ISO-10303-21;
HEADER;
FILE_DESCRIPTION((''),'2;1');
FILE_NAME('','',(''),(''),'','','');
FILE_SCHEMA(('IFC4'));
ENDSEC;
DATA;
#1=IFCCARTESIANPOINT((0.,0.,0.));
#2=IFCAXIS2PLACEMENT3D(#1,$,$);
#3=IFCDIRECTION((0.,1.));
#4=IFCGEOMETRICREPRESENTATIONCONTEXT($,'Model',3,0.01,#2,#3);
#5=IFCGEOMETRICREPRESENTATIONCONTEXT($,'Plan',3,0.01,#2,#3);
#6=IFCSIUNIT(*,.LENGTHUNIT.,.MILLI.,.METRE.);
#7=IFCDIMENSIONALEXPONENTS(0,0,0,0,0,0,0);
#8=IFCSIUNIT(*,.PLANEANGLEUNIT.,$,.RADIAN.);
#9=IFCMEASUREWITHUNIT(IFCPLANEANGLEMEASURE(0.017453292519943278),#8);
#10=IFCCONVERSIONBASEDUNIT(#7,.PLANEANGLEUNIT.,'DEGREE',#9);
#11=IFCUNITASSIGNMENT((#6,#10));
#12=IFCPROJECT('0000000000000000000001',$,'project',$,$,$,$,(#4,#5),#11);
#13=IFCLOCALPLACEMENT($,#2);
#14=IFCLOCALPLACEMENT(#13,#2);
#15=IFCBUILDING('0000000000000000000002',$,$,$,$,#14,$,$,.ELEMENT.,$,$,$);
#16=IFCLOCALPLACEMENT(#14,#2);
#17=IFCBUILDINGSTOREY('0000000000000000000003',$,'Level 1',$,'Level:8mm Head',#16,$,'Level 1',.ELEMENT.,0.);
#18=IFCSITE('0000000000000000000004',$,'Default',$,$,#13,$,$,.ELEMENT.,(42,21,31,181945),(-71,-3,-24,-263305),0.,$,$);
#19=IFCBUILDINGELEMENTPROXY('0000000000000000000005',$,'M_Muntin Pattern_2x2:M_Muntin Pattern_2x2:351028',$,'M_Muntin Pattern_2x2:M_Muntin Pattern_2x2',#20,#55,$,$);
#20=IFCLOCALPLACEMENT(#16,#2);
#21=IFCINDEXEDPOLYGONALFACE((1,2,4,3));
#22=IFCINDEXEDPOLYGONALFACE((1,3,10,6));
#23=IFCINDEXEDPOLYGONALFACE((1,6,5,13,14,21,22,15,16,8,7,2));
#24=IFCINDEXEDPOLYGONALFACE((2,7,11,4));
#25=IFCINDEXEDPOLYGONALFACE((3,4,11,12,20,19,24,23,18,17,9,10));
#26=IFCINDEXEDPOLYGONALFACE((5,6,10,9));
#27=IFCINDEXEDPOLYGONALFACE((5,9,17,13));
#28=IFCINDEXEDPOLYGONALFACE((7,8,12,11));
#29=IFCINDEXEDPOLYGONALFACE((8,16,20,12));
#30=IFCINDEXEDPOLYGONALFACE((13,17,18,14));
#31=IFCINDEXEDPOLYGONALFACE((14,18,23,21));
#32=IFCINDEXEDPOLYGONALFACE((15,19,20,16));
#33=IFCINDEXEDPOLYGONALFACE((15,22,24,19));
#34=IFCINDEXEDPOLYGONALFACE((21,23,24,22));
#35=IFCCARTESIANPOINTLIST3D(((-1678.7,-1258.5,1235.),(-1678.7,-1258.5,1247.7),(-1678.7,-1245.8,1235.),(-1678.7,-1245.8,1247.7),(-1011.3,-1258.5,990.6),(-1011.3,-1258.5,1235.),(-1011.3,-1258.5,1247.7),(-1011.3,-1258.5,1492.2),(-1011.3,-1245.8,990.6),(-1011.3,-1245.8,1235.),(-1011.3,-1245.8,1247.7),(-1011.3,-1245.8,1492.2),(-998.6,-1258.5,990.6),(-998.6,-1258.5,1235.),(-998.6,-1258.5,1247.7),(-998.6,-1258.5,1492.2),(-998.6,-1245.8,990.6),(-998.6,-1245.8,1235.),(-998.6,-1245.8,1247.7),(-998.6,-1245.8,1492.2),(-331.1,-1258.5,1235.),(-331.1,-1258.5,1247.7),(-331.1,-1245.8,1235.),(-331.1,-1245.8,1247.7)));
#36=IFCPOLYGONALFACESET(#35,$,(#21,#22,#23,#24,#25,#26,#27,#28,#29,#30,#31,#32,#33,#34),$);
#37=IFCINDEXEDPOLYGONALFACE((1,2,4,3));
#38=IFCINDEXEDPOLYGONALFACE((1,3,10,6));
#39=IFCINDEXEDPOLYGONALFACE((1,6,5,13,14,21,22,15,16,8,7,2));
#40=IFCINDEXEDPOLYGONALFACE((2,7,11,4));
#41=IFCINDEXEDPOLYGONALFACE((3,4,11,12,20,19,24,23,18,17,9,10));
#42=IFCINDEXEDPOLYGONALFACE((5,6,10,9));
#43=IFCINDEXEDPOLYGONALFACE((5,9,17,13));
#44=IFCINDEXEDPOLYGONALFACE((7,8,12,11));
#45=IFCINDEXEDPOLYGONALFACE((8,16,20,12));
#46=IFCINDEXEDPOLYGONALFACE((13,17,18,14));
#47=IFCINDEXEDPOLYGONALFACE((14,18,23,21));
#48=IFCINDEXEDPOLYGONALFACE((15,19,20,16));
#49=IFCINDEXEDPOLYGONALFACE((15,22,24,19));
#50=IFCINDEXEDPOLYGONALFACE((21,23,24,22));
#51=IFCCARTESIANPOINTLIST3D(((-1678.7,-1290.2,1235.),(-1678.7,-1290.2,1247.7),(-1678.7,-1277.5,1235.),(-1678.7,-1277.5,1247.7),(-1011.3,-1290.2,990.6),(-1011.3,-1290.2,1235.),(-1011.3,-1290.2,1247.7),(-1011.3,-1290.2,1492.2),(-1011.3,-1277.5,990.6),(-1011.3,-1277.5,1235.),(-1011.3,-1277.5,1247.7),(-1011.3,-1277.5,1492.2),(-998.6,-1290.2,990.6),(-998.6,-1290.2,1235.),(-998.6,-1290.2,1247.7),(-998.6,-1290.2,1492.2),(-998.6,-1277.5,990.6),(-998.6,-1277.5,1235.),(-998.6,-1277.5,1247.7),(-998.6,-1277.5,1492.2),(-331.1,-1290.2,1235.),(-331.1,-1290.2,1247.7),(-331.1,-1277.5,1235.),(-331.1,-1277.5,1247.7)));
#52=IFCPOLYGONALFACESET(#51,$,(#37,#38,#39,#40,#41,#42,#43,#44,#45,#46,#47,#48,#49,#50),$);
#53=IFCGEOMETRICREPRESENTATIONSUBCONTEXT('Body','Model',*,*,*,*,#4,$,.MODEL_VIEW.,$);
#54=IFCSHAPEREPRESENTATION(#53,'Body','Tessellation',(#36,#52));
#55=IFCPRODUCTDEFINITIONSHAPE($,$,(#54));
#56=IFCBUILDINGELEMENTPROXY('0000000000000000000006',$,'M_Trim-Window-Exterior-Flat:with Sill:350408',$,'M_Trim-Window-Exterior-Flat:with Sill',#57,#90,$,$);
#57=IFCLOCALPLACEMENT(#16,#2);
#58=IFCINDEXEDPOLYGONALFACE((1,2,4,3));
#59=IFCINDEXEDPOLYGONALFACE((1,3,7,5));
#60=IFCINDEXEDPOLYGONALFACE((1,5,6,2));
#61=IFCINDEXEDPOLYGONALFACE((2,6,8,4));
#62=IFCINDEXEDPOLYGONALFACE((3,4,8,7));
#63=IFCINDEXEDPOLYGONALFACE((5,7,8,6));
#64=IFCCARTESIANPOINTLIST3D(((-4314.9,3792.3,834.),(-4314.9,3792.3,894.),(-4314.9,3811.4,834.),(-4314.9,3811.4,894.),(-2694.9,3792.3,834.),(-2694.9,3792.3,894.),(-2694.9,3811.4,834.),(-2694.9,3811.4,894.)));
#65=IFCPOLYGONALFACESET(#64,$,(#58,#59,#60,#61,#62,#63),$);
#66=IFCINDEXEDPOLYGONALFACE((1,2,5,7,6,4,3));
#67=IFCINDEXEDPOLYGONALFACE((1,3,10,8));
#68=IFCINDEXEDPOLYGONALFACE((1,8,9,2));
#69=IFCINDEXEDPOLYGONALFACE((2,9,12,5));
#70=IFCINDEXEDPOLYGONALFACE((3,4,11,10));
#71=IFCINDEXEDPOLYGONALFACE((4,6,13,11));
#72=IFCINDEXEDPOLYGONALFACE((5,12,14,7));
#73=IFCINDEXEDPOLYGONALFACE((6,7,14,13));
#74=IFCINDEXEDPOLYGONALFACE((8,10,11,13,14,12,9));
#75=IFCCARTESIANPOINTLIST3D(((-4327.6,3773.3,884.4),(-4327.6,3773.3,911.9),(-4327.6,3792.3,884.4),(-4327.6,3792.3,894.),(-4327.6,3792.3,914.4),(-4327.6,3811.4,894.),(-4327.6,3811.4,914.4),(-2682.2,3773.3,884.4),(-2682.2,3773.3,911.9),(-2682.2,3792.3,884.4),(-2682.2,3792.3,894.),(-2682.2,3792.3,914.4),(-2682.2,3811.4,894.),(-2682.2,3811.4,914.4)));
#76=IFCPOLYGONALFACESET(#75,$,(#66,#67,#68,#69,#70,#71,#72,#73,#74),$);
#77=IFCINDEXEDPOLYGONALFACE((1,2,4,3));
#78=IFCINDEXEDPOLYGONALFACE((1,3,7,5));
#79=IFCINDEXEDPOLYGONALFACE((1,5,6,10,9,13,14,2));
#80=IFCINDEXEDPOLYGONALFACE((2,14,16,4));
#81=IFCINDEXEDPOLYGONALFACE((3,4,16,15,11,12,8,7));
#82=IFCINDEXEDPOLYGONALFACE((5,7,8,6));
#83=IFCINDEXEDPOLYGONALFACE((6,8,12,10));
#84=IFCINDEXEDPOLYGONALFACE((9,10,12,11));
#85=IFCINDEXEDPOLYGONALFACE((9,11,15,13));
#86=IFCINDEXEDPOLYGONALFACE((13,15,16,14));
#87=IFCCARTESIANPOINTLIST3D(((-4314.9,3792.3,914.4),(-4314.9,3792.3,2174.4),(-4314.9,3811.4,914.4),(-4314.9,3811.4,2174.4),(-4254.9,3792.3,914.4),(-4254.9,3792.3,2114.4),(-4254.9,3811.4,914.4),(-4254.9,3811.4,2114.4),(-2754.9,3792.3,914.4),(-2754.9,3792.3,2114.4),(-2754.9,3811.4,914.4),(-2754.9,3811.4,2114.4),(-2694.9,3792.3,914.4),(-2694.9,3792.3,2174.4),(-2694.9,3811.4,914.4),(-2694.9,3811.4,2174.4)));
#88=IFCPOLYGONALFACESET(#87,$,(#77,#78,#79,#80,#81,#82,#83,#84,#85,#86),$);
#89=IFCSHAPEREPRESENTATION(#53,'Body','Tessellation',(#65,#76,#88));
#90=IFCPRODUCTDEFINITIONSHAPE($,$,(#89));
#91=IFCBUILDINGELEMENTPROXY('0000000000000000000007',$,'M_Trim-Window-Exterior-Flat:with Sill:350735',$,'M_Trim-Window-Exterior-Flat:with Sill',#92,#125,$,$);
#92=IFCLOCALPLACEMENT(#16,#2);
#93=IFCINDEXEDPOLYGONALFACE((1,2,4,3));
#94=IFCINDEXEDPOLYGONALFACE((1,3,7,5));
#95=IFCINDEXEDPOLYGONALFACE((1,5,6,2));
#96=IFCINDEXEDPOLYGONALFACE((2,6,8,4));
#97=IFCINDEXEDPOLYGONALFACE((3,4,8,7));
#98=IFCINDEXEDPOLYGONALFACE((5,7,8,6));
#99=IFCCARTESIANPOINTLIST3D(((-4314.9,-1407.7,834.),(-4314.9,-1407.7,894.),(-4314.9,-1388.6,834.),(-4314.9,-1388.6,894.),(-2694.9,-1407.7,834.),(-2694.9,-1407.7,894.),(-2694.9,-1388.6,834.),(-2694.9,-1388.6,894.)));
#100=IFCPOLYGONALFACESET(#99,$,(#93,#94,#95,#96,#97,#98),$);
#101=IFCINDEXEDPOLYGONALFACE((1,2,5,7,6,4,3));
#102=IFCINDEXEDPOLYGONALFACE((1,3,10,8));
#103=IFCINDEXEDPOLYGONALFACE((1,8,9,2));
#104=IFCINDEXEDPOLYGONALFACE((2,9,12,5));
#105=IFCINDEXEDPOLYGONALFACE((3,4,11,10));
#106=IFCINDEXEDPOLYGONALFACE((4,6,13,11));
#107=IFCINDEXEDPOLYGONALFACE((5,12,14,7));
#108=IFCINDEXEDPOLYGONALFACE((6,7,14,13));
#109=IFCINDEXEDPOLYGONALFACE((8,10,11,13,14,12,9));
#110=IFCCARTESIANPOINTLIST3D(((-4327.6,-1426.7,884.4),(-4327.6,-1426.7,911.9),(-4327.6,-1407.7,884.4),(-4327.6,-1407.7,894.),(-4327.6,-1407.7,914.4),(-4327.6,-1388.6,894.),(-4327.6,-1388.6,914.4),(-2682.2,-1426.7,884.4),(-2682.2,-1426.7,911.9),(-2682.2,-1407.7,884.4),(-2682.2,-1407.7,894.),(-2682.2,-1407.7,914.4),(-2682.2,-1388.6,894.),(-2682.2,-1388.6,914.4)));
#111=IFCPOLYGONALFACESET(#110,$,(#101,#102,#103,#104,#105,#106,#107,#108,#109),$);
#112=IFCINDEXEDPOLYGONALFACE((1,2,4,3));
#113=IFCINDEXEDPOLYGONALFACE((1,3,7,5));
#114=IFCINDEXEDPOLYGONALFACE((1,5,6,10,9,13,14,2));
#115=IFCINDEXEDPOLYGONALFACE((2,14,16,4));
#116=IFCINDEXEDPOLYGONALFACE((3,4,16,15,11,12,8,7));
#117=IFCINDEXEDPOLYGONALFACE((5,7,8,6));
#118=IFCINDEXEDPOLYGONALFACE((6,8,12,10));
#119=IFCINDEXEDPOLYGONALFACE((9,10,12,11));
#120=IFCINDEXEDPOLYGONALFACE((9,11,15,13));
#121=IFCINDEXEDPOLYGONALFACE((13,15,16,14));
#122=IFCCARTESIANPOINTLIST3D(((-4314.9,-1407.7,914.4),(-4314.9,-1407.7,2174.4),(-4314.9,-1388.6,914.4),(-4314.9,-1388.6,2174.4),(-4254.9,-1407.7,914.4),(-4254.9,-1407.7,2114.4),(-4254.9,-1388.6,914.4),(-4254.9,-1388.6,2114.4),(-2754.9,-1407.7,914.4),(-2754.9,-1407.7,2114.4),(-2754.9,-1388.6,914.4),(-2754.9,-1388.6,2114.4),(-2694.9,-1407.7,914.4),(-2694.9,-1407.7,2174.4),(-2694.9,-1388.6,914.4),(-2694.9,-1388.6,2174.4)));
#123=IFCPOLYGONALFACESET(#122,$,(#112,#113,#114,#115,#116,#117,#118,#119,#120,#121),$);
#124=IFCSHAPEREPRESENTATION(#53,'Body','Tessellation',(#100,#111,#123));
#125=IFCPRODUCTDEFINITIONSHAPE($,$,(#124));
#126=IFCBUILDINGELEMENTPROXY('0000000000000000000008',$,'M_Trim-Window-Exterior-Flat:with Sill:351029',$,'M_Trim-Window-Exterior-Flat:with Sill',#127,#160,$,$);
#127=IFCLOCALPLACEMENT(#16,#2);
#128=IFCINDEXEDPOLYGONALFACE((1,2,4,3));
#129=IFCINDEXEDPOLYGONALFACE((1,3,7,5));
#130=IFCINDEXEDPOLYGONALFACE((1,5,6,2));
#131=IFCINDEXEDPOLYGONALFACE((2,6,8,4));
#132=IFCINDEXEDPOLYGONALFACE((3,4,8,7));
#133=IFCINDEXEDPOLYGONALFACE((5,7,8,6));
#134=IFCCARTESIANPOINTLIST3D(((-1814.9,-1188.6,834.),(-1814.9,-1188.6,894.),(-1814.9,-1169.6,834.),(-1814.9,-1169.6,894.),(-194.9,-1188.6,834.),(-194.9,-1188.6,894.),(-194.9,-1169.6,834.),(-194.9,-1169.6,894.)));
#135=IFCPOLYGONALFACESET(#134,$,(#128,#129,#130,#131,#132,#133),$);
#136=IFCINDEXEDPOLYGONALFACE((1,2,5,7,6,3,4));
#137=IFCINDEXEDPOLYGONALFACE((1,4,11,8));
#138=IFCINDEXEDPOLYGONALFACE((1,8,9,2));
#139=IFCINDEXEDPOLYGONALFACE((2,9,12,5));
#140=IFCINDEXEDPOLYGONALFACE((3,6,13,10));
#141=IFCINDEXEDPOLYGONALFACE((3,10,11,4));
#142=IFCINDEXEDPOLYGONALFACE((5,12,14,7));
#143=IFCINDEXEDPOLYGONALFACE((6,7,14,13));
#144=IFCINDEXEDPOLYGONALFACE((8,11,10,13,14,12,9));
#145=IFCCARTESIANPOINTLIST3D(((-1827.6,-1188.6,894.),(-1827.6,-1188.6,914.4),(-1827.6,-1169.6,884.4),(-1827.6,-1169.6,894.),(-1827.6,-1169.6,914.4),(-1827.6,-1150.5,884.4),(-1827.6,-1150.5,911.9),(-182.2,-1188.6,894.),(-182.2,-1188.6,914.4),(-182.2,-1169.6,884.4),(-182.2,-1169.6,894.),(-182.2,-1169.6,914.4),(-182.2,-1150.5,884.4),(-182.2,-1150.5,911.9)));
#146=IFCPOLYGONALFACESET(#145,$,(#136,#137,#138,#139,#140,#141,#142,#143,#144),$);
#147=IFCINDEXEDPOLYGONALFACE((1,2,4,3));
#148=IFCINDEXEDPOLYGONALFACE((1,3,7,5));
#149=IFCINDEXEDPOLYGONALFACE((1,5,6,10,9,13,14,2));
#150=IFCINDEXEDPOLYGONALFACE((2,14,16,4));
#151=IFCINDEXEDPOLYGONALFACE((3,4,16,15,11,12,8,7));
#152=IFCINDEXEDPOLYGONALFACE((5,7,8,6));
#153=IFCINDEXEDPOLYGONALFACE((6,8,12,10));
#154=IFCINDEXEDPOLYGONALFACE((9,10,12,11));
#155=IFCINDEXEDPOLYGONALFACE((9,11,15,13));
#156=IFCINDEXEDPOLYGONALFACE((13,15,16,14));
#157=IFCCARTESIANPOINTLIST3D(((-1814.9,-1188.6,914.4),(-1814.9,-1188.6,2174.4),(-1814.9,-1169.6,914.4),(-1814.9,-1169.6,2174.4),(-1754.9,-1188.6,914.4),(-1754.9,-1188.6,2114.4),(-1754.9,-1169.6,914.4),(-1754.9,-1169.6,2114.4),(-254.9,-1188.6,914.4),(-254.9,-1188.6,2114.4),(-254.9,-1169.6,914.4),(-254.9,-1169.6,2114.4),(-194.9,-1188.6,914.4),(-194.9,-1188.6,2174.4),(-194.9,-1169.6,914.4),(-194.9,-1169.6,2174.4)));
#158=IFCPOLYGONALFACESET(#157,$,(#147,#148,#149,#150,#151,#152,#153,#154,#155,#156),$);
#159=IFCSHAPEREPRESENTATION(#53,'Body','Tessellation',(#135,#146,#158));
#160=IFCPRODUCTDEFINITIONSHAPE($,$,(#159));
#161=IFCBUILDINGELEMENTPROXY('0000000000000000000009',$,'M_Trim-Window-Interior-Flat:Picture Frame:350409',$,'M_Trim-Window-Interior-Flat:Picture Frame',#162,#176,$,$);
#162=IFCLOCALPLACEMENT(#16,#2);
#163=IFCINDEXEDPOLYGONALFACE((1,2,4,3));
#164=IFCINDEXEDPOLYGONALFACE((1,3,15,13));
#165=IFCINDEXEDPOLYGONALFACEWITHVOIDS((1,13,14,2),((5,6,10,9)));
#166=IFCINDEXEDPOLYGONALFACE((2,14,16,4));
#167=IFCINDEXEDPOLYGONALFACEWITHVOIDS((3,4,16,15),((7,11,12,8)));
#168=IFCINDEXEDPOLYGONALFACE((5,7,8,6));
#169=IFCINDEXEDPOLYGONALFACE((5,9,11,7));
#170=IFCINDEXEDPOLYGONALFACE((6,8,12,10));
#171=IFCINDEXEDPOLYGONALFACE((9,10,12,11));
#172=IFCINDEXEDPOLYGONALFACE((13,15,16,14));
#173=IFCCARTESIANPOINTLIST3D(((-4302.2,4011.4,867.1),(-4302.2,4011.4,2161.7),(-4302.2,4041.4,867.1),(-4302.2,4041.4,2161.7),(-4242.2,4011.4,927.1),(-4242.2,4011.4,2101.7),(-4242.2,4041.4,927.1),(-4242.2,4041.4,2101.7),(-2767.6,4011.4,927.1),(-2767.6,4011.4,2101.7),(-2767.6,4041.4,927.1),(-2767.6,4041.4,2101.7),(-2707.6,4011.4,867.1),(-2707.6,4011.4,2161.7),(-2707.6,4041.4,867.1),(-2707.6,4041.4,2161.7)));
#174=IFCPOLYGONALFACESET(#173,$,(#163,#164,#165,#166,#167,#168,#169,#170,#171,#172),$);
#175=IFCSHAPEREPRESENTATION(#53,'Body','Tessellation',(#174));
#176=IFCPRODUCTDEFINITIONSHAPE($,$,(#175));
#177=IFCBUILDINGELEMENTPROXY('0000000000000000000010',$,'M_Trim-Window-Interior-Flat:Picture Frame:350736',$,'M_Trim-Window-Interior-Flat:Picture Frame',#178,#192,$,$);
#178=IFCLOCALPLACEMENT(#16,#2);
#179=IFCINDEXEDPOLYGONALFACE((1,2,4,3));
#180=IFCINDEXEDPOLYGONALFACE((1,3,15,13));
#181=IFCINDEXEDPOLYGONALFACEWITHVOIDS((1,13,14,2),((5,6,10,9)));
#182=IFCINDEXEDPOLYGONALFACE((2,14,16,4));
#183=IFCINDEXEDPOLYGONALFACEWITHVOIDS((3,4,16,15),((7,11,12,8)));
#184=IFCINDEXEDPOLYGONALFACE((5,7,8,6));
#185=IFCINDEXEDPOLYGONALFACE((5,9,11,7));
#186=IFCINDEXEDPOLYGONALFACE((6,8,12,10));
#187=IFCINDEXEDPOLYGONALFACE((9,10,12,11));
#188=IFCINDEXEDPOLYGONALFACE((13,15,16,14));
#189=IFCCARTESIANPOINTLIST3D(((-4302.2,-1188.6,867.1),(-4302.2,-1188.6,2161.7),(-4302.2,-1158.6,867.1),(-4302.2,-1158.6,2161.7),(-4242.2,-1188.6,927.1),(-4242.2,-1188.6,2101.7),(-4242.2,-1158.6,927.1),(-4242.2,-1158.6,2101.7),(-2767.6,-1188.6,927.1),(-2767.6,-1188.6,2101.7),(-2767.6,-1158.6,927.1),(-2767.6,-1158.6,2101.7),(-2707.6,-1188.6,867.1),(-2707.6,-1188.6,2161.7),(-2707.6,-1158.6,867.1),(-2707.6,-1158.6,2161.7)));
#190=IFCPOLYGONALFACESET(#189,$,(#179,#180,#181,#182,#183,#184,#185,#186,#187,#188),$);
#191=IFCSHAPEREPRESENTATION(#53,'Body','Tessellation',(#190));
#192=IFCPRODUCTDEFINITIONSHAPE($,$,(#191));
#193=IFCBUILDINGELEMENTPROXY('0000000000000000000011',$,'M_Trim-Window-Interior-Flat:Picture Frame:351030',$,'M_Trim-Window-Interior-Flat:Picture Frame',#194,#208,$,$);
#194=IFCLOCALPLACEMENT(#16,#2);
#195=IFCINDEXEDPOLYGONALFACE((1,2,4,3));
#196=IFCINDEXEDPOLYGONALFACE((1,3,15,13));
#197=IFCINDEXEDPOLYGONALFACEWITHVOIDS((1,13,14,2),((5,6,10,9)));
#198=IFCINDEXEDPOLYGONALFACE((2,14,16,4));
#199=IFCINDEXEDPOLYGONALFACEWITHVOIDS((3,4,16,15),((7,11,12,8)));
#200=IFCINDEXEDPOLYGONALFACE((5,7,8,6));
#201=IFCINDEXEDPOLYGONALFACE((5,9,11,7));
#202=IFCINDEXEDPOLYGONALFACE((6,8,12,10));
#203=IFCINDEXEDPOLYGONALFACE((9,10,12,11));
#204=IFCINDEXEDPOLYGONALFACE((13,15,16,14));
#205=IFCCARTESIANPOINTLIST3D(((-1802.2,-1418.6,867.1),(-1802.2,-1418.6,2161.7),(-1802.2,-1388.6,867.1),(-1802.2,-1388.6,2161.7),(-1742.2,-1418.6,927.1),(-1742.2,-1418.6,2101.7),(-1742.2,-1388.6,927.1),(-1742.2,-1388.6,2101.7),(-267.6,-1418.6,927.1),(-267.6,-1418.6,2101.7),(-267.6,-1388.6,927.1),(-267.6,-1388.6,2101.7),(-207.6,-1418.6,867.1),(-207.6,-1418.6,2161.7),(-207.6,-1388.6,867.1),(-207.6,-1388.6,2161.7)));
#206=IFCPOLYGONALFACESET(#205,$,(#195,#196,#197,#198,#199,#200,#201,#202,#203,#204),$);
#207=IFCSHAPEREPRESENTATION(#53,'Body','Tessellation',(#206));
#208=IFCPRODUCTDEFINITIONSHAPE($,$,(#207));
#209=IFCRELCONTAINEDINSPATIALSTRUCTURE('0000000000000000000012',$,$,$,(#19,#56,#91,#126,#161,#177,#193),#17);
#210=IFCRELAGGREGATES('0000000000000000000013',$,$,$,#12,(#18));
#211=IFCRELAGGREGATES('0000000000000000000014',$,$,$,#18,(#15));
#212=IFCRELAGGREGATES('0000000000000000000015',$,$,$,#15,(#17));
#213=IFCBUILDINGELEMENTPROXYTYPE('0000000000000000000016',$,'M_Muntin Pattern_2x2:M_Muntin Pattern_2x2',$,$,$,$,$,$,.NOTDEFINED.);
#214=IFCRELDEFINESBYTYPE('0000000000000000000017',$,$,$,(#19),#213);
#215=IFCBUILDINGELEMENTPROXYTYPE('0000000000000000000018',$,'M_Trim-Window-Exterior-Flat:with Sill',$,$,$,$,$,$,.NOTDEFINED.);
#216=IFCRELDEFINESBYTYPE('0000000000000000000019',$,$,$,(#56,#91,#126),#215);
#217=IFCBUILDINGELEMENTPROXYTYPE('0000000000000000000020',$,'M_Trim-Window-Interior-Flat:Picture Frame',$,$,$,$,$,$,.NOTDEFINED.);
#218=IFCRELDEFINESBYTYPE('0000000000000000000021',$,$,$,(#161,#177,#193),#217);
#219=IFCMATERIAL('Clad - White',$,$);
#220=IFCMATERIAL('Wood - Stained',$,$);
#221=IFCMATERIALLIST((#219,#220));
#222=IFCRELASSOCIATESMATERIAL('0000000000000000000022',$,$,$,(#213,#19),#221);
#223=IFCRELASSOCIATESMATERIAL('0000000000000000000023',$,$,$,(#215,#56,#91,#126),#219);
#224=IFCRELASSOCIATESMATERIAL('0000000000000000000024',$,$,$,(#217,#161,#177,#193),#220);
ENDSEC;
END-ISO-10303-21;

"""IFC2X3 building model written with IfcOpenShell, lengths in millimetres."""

from ifc_helpers import new_model, entity, si_unit, converted_unit, direction, frame, frame_2d, origin, place, context, subcontext, project, spatial, polyline, rectangle, outline, extrude, source, transform, mapped, material, material_list, type_object, type_shapes, element, save


model = new_model("IFC2X3")

# Units and contexts
model_context = context("Model", 3, precision=0.01, world=origin(), true_north=direction((0.0, 1.0)))
plan_context = context("Plan", 3, precision=0.01, world=origin(), true_north=direction((0.0, 1.0)))
body_context = subcontext(model_context, "Body", "Model", "MODEL_VIEW")
ifc_project = project(units=[si_unit("LENGTHUNIT", "METRE", prefix="MILLI"), converted_unit("PLANEANGLEUNIT", "DEGREE", entity("IfcPlaneAngleMeasure", 0.017453292519943278), si_unit("PLANEANGLEUNIT", "RADIAN"), dimensions=[0, 0, 0, 0, 0, 0, 0])], contexts=[model_context, plan_context])

# Site, building, storey
site_placement = place(None, origin())
site = spatial("IfcSite", under=ifc_project, at=site_placement, Name="Default", CompositionType="ELEMENT", RefLatitude=(42, 21, 31, 181945), RefLongitude=(-71, -3, -24, -263305), RefElevation=0.0)
building_placement = place(site_placement, origin())
building = spatial("IfcBuilding", under=site, at=building_placement, CompositionType="ELEMENT")
storey_placement = place(building_placement, origin())
storey = spatial("IfcBuildingStorey", under=building, at=storey_placement, Name="Level 1", ObjectType="Level:8mm Head", LongName="Level 1", CompositionType="ELEMENT", Elevation=0.0)

# Shared definitions
ifc_material_1 = material(Name="Wood - Stained")

# Building element proxies
ifc_material_2 = material(Name="Clad - White")
ifc_material_list_1 = material_list([ifc_material_2, ifc_material_1])
building_element_proxy_type_1 = type_object("IfcBuildingElementProxyType", Name="M_Muntin Pattern_2x2:M_Muntin Pattern_2x2", PredefinedType="NOTDEFINED", material=ifc_material_list_1)
shared_shape_1 = source(origin(), body_context, "Body", "SweptSolid", [
    extrude(outline(polyline([(6.4, -6.4), (250.8, -6.4), (250.8, 6.3), (6.4, 6.3), (6.4, 673.8), (-6.3, 673.8), (-6.3, 6.3), (-250.8, 6.3), (-250.8, -6.4), (-6.3, -6.4), (-6.3, -673.8), (6.4, -673.8), (6.4, -6.4)])), frame((0.0, 9.5, 250.8), z_axis=(0.0, 1.0, 0.0), x_axis=(0.0, 0.0, 1.0)), (0.0, 0.0, 1.0), 12.7),
    extrude(outline(polyline([(6.4, -6.4), (250.8, -6.4), (250.8, 6.3), (6.4, 6.3), (6.4, 673.8), (-6.3, 673.8), (-6.3, 6.3), (-250.8, 6.3), (-250.8, -6.4), (-6.3, -6.4), (-6.3, -673.8), (6.4, -673.8), (6.4, -6.4)])), frame((0.0, -22.2, 250.8), z_axis=(0.0, 1.0, 0.0), x_axis=(0.0, 0.0, 1.0)), (0.0, 0.0, 1.0), 12.7),
])
type_shapes(building_element_proxy_type_1, [shared_shape_1])
for number, where, name in (
    (1, (-1004.9, -1268.0, 990.6), "M_Muntin Pattern_2x2:M_Muntin Pattern_2x2:351028"),
):
    element("IfcBuildingElementProxy", number, at=place(storey_placement, frame(where)), inside=storey, type_object=building_element_proxy_type_1, material=ifc_material_list_1, Name=name, ObjectType="M_Muntin Pattern_2x2:M_Muntin Pattern_2x2", context=body_context, shape_type="MappedRepresentation", body=[
        mapped(shared_shape_1, transform((0.0, 0.0, 0.0), scale=1.0)),
    ])
building_element_proxy_type_2 = type_object("IfcBuildingElementProxyType", Name="M_Trim-Window-Exterior-Flat:with Sill", PredefinedType="NOTDEFINED", material=ifc_material_2)
shared_shape_2 = source(origin(), body_context, "Body", "SweptSolid", [
    extrude(rectangle(XDim=1620.0, YDim=60.0, at=frame_2d((0.0, 0.0), x_axis=(1.0, 0.0))), frame((0.0, -1250.4, 0.0), z_axis=(0.0, 0.0, 1.0), x_axis=(-1.0, 0.0, 0.0)), (0.0, 0.0, 1.0), 19.0),
    extrude(outline(polyline([(-19.0, -15.2), (0.0, -15.2), (0.0, -5.7), (19.0, -5.7), (19.0, 14.8), (0.0, 14.8), (-19.0, 12.3), (-19.0, -15.2)])), frame((-822.7, -1214.8, 19.0), z_axis=(1.0, 0.0, 0.0), x_axis=(0.0, 0.0, -1.0)), (0.0, 0.0, 1.0), 1645.4),
    extrude(outline(polyline([(-645.0, -810.0), (615.0, -810.0), (615.0, -750.0), (-585.0, -750.0), (-585.0, 750.0), (615.0, 750.0), (615.0, 810.0), (-645.0, 810.0), (-645.0, -810.0)])), frame((0.0, -585.0, 0.0), z_axis=(0.0, 0.0, 1.0), x_axis=(0.0, -1.0, 0.0)), (0.0, 0.0, 1.0), 19.0),
])
type_shapes(building_element_proxy_type_2, [shared_shape_2])
for number, where, z_axis, x_axis, name in (
    (2, (-3504.9, 3811.4, 2114.4), (0.0, -1.0, 0.0), (1.0, 0.0, 0.0), "M_Trim-Window-Exterior-Flat:with Sill:350408"),
    (3, (-3504.9, -1388.6, 2114.4), (0.0, -1.0, 0.0), (1.0, 0.0, 0.0), "M_Trim-Window-Exterior-Flat:with Sill:350735"),
    (4, (-1004.9, -1188.6, 2114.4), (0.0, 1.0, 0.0), (-1.0, 0.0, 0.0), "M_Trim-Window-Exterior-Flat:with Sill:351029"),
):
    element("IfcBuildingElementProxy", number, at=place(storey_placement, frame(where, z_axis=z_axis, x_axis=x_axis)), inside=storey, type_object=building_element_proxy_type_2, material=ifc_material_2, Name=name, ObjectType="M_Trim-Window-Exterior-Flat:with Sill", context=body_context, shape_type="MappedRepresentation", body=[
        mapped(shared_shape_2, transform((0.0, 0.0, 0.0), scale=1.0)),
    ])
building_element_proxy_type_3 = type_object("IfcBuildingElementProxyType", Name="M_Trim-Window-Interior-Flat:Picture Frame", PredefinedType="NOTDEFINED", material=ifc_material_1)
shared_shape_3 = source(origin(), body_context, "Body", "SweptSolid", [
    extrude(outline(polyline([(-797.3, -647.3), (797.3, -647.3), (797.3, 647.3), (-797.3, 647.3), (-797.3, -647.3)]), holes=[polyline([(-737.3, -587.3), (-737.3, 587.3), (737.3, 587.3), (737.3, -587.3), (-737.3, -587.3)])]), frame((0.0, -600.0, 0.0), z_axis=(0.0, 0.0, 1.0), x_axis=(-1.0, 0.0, 0.0)), (0.0, 0.0, 1.0), 30.0),
])
type_shapes(building_element_proxy_type_3, [shared_shape_3])
for number, where, z_axis, x_axis, name in (
    (5, (-3504.9, 4011.4, 2114.4), (0.0, 1.0, 0.0), (-1.0, 0.0, 0.0), "M_Trim-Window-Interior-Flat:Picture Frame:350409"),
    (6, (-3504.9, -1188.6, 2114.4), (0.0, 1.0, 0.0), (-1.0, 0.0, 0.0), "M_Trim-Window-Interior-Flat:Picture Frame:350736"),
    (7, (-1004.9, -1388.6, 2114.4), (0.0, -1.0, 0.0), (1.0, 0.0, 0.0), "M_Trim-Window-Interior-Flat:Picture Frame:351030"),
):
    element("IfcBuildingElementProxy", number, at=place(storey_placement, frame(where, z_axis=z_axis, x_axis=x_axis)), inside=storey, type_object=building_element_proxy_type_3, material=ifc_material_1, Name=name, ObjectType="M_Trim-Window-Interior-Flat:Picture Frame", context=body_context, shape_type="MappedRepresentation", body=[
        mapped(shared_shape_3, transform((0.0, 0.0, 0.0), scale=1.0)),
    ])

save(model, "model.ifc")
